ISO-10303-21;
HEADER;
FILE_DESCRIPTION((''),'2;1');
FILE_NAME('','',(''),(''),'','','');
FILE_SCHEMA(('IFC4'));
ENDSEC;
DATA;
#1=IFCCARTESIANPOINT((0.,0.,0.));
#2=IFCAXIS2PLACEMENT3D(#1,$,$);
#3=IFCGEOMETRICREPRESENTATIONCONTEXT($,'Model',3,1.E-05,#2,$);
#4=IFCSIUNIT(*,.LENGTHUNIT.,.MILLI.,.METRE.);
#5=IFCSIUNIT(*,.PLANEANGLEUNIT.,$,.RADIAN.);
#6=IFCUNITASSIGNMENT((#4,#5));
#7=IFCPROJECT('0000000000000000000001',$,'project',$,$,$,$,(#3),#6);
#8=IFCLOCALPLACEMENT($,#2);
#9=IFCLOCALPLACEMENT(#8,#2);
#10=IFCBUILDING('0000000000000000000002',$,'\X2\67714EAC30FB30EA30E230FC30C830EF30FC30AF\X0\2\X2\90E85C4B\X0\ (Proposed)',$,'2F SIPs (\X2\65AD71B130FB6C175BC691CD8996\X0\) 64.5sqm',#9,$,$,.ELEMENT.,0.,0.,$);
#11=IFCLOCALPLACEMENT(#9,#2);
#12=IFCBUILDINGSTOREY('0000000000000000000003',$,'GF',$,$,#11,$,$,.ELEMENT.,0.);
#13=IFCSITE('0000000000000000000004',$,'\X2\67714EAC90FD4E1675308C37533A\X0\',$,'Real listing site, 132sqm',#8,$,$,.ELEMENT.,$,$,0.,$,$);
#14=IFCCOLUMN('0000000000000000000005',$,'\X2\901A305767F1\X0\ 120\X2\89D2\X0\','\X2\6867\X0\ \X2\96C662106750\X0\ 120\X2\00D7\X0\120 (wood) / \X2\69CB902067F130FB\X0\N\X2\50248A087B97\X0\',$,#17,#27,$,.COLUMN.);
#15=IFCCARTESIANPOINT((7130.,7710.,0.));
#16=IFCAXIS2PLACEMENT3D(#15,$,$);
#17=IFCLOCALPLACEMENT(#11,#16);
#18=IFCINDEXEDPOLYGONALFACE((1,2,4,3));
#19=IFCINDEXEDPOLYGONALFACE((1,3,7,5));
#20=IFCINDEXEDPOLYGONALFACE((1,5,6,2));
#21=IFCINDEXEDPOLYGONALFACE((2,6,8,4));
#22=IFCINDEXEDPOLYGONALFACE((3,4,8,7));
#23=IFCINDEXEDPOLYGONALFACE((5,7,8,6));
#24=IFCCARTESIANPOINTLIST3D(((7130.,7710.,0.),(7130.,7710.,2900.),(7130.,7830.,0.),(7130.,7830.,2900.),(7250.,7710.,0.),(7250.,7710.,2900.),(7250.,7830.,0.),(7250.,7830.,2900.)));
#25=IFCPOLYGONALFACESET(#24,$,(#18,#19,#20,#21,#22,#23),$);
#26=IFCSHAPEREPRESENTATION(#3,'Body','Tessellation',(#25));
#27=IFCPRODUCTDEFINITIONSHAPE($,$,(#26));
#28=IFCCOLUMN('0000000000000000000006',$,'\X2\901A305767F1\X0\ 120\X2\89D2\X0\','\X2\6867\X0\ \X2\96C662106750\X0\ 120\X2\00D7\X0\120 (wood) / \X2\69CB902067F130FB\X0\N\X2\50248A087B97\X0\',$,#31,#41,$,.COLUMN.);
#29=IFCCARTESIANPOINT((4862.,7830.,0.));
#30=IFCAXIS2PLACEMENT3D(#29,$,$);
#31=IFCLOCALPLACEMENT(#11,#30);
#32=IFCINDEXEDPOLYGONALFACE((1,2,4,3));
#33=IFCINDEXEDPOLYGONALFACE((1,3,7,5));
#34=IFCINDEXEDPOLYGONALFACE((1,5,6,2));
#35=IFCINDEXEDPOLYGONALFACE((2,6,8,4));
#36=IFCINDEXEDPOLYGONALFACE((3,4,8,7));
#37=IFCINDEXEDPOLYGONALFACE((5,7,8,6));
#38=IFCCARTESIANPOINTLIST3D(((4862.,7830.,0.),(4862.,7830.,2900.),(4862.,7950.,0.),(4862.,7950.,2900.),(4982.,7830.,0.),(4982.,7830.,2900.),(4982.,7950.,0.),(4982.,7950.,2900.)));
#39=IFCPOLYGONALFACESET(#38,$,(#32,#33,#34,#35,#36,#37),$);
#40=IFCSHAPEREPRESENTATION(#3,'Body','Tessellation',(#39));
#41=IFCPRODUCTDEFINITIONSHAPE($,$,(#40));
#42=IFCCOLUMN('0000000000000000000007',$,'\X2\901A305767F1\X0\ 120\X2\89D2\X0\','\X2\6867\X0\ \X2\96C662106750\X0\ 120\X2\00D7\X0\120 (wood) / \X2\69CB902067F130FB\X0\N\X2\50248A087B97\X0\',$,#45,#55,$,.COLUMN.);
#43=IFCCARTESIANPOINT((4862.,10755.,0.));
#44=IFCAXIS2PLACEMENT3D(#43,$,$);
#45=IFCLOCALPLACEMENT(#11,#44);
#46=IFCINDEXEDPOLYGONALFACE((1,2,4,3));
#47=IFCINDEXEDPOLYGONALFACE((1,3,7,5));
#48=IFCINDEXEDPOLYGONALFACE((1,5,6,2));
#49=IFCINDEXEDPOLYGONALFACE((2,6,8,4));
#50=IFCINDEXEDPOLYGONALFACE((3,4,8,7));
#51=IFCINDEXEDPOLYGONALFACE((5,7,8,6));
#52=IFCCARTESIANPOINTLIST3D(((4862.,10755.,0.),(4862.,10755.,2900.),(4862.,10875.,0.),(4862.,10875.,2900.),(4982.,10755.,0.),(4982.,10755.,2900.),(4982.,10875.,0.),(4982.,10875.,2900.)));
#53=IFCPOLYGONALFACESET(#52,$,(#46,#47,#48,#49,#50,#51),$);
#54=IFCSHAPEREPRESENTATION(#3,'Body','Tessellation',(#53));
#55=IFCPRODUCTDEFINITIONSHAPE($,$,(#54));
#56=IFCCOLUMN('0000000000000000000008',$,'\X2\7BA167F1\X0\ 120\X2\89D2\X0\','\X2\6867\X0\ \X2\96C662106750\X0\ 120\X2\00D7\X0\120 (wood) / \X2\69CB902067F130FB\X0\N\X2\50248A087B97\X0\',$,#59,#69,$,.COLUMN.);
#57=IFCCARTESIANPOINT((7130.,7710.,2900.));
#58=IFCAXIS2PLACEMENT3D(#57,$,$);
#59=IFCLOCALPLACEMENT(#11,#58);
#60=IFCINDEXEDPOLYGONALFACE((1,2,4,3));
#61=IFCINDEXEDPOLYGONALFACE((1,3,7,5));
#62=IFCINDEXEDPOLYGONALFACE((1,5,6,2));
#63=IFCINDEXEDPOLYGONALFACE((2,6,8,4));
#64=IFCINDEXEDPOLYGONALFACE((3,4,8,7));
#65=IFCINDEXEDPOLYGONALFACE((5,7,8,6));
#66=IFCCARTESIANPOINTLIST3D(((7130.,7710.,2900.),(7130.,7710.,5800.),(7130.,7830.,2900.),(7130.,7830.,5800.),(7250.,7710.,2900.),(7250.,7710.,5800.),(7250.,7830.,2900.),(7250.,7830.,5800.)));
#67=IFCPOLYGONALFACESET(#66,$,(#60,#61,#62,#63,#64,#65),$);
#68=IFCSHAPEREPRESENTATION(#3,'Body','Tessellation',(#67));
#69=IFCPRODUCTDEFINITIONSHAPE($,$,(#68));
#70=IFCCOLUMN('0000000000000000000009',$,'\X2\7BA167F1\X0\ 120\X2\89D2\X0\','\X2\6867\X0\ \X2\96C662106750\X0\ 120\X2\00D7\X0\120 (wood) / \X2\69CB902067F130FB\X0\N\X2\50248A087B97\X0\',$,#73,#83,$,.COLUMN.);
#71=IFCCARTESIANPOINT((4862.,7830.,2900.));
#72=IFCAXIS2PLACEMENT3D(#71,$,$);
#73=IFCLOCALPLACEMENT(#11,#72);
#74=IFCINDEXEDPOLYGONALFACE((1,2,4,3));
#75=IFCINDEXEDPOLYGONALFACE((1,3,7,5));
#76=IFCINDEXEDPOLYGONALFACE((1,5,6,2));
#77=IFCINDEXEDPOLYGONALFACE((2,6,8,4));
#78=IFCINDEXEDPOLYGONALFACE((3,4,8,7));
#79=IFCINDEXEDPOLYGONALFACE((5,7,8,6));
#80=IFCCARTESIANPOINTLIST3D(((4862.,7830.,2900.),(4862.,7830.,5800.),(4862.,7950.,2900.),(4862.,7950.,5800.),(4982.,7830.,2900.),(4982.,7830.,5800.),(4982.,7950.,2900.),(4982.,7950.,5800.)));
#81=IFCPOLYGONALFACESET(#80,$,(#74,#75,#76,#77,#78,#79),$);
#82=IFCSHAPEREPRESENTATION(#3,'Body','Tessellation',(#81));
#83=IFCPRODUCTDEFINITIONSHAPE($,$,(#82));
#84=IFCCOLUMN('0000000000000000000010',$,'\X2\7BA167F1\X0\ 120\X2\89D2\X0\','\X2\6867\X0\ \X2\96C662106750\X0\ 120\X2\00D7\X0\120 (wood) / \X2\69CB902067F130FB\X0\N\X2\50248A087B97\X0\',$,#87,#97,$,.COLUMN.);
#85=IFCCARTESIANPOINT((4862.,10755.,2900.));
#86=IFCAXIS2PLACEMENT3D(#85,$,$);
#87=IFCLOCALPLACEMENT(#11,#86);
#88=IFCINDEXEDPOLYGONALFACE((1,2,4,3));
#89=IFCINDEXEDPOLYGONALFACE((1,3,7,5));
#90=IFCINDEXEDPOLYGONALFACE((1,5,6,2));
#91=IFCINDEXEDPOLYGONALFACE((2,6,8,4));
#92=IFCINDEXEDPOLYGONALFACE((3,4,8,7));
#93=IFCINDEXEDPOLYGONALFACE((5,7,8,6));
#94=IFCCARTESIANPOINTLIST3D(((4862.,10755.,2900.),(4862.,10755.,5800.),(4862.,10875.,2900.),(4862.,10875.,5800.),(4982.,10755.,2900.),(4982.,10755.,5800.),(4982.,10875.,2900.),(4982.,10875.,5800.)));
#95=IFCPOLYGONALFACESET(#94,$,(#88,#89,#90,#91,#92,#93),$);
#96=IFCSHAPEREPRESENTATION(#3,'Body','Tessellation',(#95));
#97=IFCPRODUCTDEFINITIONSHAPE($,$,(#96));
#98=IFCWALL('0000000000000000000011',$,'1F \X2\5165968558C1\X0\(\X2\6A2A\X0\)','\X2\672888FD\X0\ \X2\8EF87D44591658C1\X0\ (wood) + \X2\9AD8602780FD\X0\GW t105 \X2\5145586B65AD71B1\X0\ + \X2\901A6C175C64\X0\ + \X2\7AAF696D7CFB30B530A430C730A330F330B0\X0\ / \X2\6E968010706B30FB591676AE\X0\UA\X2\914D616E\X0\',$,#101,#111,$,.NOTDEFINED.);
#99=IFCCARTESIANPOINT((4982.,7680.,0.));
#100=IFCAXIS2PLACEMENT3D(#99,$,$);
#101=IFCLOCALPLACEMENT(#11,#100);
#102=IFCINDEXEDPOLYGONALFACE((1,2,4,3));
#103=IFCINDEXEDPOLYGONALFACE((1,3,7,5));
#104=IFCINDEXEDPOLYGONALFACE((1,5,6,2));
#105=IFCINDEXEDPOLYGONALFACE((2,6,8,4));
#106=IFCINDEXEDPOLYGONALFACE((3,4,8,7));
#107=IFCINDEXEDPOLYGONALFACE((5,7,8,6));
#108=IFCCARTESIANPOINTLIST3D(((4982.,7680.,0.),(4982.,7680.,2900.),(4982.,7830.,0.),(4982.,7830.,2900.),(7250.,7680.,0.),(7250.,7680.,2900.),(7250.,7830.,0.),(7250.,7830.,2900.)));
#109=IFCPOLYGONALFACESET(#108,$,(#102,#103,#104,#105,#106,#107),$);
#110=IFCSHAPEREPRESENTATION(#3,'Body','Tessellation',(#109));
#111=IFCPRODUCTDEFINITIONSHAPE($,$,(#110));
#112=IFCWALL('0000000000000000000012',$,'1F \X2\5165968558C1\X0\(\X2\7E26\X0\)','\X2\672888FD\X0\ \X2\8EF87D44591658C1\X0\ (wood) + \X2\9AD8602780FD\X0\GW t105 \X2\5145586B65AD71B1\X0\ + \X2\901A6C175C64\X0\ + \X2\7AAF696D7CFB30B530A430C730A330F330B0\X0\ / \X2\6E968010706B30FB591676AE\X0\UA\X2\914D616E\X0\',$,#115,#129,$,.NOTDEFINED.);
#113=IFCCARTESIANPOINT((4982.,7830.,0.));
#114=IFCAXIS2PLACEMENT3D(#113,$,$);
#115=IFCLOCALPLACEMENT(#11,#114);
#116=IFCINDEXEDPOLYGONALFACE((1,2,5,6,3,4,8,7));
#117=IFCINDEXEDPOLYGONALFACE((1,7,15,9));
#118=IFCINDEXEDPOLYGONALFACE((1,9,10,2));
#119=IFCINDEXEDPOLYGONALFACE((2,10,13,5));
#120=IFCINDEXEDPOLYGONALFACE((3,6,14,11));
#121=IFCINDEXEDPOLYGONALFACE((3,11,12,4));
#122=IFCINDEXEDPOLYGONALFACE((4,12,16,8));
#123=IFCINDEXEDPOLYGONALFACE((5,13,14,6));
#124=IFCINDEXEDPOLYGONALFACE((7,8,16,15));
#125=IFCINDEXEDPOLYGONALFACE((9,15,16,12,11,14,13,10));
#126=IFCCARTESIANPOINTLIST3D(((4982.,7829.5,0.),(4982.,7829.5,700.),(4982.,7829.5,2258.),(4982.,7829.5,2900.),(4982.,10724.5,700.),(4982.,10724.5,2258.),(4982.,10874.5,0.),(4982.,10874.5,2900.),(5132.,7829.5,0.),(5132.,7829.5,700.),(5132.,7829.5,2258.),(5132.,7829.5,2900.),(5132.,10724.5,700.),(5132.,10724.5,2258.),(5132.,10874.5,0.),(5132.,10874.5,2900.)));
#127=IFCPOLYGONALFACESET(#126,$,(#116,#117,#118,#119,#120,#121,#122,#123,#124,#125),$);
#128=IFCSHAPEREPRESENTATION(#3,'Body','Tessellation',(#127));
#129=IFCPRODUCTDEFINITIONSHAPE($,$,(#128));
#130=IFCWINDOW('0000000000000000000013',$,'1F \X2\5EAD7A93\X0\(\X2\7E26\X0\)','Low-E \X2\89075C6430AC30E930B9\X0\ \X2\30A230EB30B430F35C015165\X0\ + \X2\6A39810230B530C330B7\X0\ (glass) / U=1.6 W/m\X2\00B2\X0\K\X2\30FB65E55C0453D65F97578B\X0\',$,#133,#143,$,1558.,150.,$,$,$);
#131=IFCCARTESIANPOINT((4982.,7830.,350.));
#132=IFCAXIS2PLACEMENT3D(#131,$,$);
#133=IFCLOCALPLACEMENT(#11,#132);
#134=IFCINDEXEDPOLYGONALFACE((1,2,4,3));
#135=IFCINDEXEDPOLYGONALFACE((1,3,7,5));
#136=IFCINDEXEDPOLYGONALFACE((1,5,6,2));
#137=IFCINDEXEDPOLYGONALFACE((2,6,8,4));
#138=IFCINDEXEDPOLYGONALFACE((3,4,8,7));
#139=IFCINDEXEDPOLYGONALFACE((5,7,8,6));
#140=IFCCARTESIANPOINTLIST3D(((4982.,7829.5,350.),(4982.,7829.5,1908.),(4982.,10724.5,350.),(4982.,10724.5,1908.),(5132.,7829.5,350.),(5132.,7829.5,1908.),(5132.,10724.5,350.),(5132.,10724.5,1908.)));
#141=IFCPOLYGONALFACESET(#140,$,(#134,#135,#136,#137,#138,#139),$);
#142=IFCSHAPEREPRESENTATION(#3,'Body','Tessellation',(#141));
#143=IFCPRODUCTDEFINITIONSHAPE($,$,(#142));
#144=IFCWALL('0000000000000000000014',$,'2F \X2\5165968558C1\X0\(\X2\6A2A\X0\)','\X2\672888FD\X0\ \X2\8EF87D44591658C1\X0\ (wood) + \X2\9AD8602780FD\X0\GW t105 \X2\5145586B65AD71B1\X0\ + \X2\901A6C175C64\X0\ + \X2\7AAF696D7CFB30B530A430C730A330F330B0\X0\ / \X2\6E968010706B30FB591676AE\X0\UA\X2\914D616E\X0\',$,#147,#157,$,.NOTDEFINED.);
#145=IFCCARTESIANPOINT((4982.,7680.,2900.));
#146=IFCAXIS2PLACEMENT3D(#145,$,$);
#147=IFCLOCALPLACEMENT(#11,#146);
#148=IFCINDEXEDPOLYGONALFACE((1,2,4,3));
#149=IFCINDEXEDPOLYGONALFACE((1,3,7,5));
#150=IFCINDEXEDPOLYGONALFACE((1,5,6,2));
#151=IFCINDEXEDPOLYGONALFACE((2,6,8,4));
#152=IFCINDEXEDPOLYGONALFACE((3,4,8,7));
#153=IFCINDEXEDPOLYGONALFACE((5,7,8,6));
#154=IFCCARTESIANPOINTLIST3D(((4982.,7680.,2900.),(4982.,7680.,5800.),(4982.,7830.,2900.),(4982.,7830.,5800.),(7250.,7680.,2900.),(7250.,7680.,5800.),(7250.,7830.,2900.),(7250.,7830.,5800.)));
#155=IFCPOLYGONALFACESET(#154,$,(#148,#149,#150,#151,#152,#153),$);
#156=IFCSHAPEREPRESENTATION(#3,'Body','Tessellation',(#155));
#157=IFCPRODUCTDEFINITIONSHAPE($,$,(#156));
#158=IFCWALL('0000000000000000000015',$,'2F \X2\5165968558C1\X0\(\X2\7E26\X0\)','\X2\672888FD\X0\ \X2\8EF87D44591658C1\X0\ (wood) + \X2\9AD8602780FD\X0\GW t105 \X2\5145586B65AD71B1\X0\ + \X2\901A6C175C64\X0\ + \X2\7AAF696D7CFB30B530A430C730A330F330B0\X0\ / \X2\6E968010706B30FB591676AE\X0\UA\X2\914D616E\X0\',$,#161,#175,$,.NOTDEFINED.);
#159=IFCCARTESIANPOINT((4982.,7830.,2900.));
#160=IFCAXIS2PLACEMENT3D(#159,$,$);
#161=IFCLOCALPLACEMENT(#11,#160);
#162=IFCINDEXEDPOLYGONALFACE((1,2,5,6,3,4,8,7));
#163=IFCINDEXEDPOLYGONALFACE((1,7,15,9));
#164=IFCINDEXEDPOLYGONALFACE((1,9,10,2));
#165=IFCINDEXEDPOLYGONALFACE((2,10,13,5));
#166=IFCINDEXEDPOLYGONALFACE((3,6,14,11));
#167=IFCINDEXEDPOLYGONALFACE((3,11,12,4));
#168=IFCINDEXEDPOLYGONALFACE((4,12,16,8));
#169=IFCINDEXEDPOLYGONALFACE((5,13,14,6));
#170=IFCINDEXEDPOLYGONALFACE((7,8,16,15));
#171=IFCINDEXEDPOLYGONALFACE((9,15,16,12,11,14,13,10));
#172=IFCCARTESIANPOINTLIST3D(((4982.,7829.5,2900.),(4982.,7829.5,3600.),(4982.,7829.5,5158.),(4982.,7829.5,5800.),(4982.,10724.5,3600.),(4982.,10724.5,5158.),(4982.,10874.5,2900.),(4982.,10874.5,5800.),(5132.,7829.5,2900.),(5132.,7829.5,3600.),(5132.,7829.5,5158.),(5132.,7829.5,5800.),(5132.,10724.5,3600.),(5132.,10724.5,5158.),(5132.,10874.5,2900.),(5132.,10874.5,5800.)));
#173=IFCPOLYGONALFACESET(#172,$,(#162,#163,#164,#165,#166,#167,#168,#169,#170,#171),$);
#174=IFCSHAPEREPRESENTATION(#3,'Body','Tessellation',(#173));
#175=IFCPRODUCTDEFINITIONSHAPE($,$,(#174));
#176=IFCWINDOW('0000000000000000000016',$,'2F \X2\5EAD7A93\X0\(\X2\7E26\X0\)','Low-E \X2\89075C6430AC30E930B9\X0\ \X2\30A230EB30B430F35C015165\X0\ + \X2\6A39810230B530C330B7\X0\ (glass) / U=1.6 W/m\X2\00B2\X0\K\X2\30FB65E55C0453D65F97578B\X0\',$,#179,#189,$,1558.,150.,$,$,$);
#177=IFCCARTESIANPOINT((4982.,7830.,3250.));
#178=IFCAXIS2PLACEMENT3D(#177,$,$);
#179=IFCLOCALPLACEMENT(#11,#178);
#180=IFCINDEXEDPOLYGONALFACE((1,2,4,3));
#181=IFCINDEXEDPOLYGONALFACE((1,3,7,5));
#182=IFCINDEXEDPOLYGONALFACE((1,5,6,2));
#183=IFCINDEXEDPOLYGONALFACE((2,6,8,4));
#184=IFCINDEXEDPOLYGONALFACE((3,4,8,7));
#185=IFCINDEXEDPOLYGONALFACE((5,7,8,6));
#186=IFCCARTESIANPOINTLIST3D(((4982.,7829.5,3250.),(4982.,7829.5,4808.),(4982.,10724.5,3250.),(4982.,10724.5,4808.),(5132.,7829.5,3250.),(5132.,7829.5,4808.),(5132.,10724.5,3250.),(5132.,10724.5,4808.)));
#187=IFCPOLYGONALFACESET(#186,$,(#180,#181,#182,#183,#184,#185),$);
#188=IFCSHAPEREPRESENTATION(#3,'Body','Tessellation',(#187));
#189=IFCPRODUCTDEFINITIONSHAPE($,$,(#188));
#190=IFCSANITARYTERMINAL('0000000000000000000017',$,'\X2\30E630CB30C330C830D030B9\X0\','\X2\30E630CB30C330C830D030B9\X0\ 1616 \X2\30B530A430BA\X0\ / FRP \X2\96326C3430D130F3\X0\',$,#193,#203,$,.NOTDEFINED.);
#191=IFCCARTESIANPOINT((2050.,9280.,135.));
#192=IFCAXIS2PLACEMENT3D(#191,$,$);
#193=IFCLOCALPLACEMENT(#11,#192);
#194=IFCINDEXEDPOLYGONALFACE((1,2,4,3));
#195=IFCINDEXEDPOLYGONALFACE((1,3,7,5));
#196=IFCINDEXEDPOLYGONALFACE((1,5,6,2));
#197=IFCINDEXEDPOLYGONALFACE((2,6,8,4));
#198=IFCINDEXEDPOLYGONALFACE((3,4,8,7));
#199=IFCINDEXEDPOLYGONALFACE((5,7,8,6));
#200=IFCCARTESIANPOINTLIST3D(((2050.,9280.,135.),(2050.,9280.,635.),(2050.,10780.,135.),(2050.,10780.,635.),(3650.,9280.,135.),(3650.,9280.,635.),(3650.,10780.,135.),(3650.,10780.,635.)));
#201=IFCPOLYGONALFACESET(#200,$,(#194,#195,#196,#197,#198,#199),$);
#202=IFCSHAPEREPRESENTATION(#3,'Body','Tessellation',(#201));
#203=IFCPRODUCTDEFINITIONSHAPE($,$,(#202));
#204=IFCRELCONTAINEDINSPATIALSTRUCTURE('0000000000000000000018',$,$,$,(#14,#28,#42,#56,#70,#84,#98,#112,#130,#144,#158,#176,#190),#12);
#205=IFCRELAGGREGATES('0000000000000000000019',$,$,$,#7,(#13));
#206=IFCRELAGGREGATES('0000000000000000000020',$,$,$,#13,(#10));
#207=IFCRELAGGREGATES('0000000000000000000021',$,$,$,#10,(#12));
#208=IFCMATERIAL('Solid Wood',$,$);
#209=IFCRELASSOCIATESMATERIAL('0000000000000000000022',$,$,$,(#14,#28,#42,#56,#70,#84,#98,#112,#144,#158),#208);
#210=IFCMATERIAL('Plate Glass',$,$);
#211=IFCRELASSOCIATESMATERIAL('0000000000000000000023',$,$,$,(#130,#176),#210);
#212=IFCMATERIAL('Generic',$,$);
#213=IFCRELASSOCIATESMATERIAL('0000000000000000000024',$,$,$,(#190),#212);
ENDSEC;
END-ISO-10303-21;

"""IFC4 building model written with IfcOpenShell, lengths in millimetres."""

from ifc_helpers import new_model, si_unit, frame, frame_2d, origin, place, context, project, spatial, rectangle, extrude, material, element, fill, save


model = new_model("IFC4")

# Units and contexts
model_context = context("Model", 3, precision=1e-05, world=origin())
ifc_project = project(units=[si_unit("LENGTHUNIT", "METRE", prefix="MILLI"), si_unit("PLANEANGLEUNIT", "RADIAN")], contexts=[model_context])

# Site, building, storey
site_placement = place(None, origin())
site = spatial("IfcSite", under=ifc_project, at=site_placement, Name="東京都世田谷区", ObjectType="Real listing site, 132sqm", CompositionType="ELEMENT", RefElevation=0.0)
building_placement = place(site_placement, origin())
building = spatial("IfcBuilding", under=site, at=building_placement, Name="東京・リモートワーク2部屋 (Proposed)", ObjectType="2F SIPs (断熱・気密重視) 64.5sqm", CompositionType="ELEMENT", ElevationOfRefHeight=0.0, ElevationOfTerrain=0.0)
storey_placement = place(building_placement, origin())
storey = spatial("IfcBuildingStorey", under=building, at=storey_placement, Name="GF", CompositionType="ELEMENT", Elevation=0.0)

# Columns
ifc_material_1 = material(Name="Solid Wood")
column_1_placement = place(storey_placement, frame((7130.0, 7710.0, 0.0)))
element("IfcColumn", 1, at=column_1_placement, inside=storey, material=ifc_material_1, Name="通し柱 120角", Description="桧 集成材 120×120 (wood) / 構造柱・N値計算", PredefinedType="COLUMN", context=model_context, shape_type="SweptSolid", body=[
    extrude(rectangle(XDim=120.0, YDim=120.0, at=frame_2d((60.0, 60.0))), frame((7130.0, 7710.0, 0.0)), (0.0, 0.0, 1.0), 2900.0),
])
column_2_placement = place(storey_placement, frame((4862.0, 7830.0, 0.0)))
element("IfcColumn", 2, at=column_2_placement, inside=storey, material=ifc_material_1, Name="通し柱 120角", Description="桧 集成材 120×120 (wood) / 構造柱・N値計算", PredefinedType="COLUMN", context=model_context, shape_type="SweptSolid", body=[
    extrude(rectangle(XDim=120.0, YDim=120.0, at=frame_2d((60.0, 60.0))), frame((4862.0, 7830.0, 0.0)), (0.0, 0.0, 1.0), 2900.0),
])
column_3_placement = place(storey_placement, frame((4862.0, 10755.0, 0.0)))
element("IfcColumn", 3, at=column_3_placement, inside=storey, material=ifc_material_1, Name="通し柱 120角", Description="桧 集成材 120×120 (wood) / 構造柱・N値計算", PredefinedType="COLUMN", context=model_context, shape_type="SweptSolid", body=[
    extrude(rectangle(XDim=120.0, YDim=120.0, at=frame_2d((60.0, 60.0))), frame((4862.0, 10755.0, 0.0)), (0.0, 0.0, 1.0), 2900.0),
])
column_4_placement = place(storey_placement, frame((7130.0, 7710.0, 2900.0)))
element("IfcColumn", 4, at=column_4_placement, inside=storey, material=ifc_material_1, Name="管柱 120角", Description="桧 集成材 120×120 (wood) / 構造柱・N値計算", PredefinedType="COLUMN", context=model_context, shape_type="SweptSolid", body=[
    extrude(rectangle(XDim=120.0, YDim=120.0, at=frame_2d((60.0, 60.0))), frame((7130.0, 7710.0, 2900.0)), (0.0, 0.0, 1.0), 2900.0),
])
column_5_placement = place(storey_placement, frame((4862.0, 7830.0, 2900.0)))
element("IfcColumn", 5, at=column_5_placement, inside=storey, material=ifc_material_1, Name="管柱 120角", Description="桧 集成材 120×120 (wood) / 構造柱・N値計算", PredefinedType="COLUMN", context=model_context, shape_type="SweptSolid", body=[
    extrude(rectangle(XDim=120.0, YDim=120.0, at=frame_2d((60.0, 60.0))), frame((4862.0, 7830.0, 2900.0)), (0.0, 0.0, 1.0), 2900.0),
])
column_6_placement = place(storey_placement, frame((4862.0, 10755.0, 2900.0)))
element("IfcColumn", 6, at=column_6_placement, inside=storey, material=ifc_material_1, Name="管柱 120角", Description="桧 集成材 120×120 (wood) / 構造柱・N値計算", PredefinedType="COLUMN", context=model_context, shape_type="SweptSolid", body=[
    extrude(rectangle(XDim=120.0, YDim=120.0, at=frame_2d((60.0, 60.0))), frame((4862.0, 10755.0, 2900.0)), (0.0, 0.0, 1.0), 2900.0),
])

# Wall
wall_1_placement = place(storey_placement, frame((4982.0, 7680.0, 0.0)))
element("IfcWall", 7, at=wall_1_placement, inside=storey, material=ifc_material_1, Name="1F 入隅壁(横)", Description="木製 軸組外壁 (wood) + 高性能GW t105 充填断熱 + 通気層 + 窯業系サイディング / 準耐火・外皮UA配慮", PredefinedType="NOTDEFINED", context=model_context, shape_type="SweptSolid", body=[
    extrude(rectangle(XDim=2268.0, YDim=150.0, at=frame_2d((1134.0, 75.0))), frame((4982.0, 7680.0, 0.0)), (0.0, 0.0, 1.0), 2900.0),
])

# Wall, opening, window
wall_2_placement = place(storey_placement, frame((4982.0, 7830.0, 0.0)))
wall_2 = element("IfcWall", 8, at=wall_2_placement, inside=storey, material=ifc_material_1, Name="1F 入隅壁(縦)", Description="木製 軸組外壁 (wood) + 高性能GW t105 充填断熱 + 通気層 + 窯業系サイディング / 準耐火・外皮UA配慮", PredefinedType="NOTDEFINED", context=model_context, shape_type="SweptSolid", body=[
    extrude(rectangle(XDim=150.0, YDim=3045.0, at=frame_2d((75.0, 1522.0))), frame((4982.0, 7830.0, 0.0)), (0.0, 0.0, 1.0), 2900.0),
])
opening_1_placement = place(storey_placement, frame((4982.0, 7830.0, 350.0)))
opening_1 = element("IfcOpeningElement", 9, at=opening_1_placement, cuts=wall_2, PredefinedType="NOTDEFINED", context=model_context, shape_type="SweptSolid", body=[
    extrude(rectangle(XDim=150.0, YDim=2895.0, at=frame_2d((75.0, 1447.0))), frame((4982.0, 7830.0, 350.0)), (0.0, 0.0, 1.0), 1558.0),
])
ifc_material_2 = material(Name="Plate Glass")
window_1_placement = place(storey_placement, frame((4982.0, 7830.0, 350.0)))
window_1 = element("IfcWindow", 10, at=window_1_placement, inside=storey, material=ifc_material_2, Name="1F 庭窓(縦)", Description="Low-E 複層ガラス アルゴン封入 + 樹脂サッシ (glass) / U=1.6 W/m²K・日射取得型", OverallHeight=1558.0, OverallWidth=150.0, context=model_context, shape_type="SweptSolid", body=[
    extrude(rectangle(XDim=150.0, YDim=2895.0, at=frame_2d((75.0, 1447.0))), frame((4982.0, 7830.0, 350.0)), (0.0, 0.0, 1.0), 1558.0),
])
fill(opening_1, window_1)

# Wall
wall_3_placement = place(storey_placement, frame((4982.0, 7680.0, 2900.0)))
element("IfcWall", 11, at=wall_3_placement, inside=storey, material=ifc_material_1, Name="2F 入隅壁(横)", Description="木製 軸組外壁 (wood) + 高性能GW t105 充填断熱 + 通気層 + 窯業系サイディング / 準耐火・外皮UA配慮", PredefinedType="NOTDEFINED", context=model_context, shape_type="SweptSolid", body=[
    extrude(rectangle(XDim=2268.0, YDim=150.0, at=frame_2d((1134.0, 75.0))), frame((4982.0, 7680.0, 2900.0)), (0.0, 0.0, 1.0), 2900.0),
])

# Wall, opening, window
wall_4_placement = place(storey_placement, frame((4982.0, 7830.0, 2900.0)))
wall_4 = element("IfcWall", 12, at=wall_4_placement, inside=storey, material=ifc_material_1, Name="2F 入隅壁(縦)", Description="木製 軸組外壁 (wood) + 高性能GW t105 充填断熱 + 通気層 + 窯業系サイディング / 準耐火・外皮UA配慮", PredefinedType="NOTDEFINED", context=model_context, shape_type="SweptSolid", body=[
    extrude(rectangle(XDim=150.0, YDim=3045.0, at=frame_2d((75.0, 1522.0))), frame((4982.0, 7830.0, 2900.0)), (0.0, 0.0, 1.0), 2900.0),
])
opening_2_placement = place(storey_placement, frame((4982.0, 7830.0, 3250.0)))
opening_2 = element("IfcOpeningElement", 13, at=opening_2_placement, cuts=wall_4, PredefinedType="NOTDEFINED", context=model_context, shape_type="SweptSolid", body=[
    extrude(rectangle(XDim=150.0, YDim=2895.0, at=frame_2d((75.0, 1447.0))), frame((4982.0, 7830.0, 3250.0)), (0.0, 0.0, 1.0), 1558.0),
])
window_2_placement = place(storey_placement, frame((4982.0, 7830.0, 3250.0)))
window_2 = element("IfcWindow", 14, at=window_2_placement, inside=storey, material=ifc_material_2, Name="2F 庭窓(縦)", Description="Low-E 複層ガラス アルゴン封入 + 樹脂サッシ (glass) / U=1.6 W/m²K・日射取得型", OverallHeight=1558.0, OverallWidth=150.0, context=model_context, shape_type="SweptSolid", body=[
    extrude(rectangle(XDim=150.0, YDim=2895.0, at=frame_2d((75.0, 1447.0))), frame((4982.0, 7830.0, 3250.0)), (0.0, 0.0, 1.0), 1558.0),
])
fill(opening_2, window_2)

# Sanitary terminal
ifc_material_3 = material(Name="Generic")
sanitary_terminal_1_placement = place(storey_placement, frame((2050.0, 9280.0, 135.0)))
element("IfcSanitaryTerminal", 15, at=sanitary_terminal_1_placement, inside=storey, material=ifc_material_3, Name="ユニットバス", Description="ユニットバス 1616 サイズ / FRP 防水パン", PredefinedType="NOTDEFINED", context=model_context, shape_type="SweptSolid", body=[
    extrude(rectangle(XDim=1600.0, YDim=1500.0, at=frame_2d((800.0, 750.0))), frame((2050.0, 9280.0, 135.0)), (0.0, 0.0, 1.0), 500.0),
])

save(model, "model.ifc")
